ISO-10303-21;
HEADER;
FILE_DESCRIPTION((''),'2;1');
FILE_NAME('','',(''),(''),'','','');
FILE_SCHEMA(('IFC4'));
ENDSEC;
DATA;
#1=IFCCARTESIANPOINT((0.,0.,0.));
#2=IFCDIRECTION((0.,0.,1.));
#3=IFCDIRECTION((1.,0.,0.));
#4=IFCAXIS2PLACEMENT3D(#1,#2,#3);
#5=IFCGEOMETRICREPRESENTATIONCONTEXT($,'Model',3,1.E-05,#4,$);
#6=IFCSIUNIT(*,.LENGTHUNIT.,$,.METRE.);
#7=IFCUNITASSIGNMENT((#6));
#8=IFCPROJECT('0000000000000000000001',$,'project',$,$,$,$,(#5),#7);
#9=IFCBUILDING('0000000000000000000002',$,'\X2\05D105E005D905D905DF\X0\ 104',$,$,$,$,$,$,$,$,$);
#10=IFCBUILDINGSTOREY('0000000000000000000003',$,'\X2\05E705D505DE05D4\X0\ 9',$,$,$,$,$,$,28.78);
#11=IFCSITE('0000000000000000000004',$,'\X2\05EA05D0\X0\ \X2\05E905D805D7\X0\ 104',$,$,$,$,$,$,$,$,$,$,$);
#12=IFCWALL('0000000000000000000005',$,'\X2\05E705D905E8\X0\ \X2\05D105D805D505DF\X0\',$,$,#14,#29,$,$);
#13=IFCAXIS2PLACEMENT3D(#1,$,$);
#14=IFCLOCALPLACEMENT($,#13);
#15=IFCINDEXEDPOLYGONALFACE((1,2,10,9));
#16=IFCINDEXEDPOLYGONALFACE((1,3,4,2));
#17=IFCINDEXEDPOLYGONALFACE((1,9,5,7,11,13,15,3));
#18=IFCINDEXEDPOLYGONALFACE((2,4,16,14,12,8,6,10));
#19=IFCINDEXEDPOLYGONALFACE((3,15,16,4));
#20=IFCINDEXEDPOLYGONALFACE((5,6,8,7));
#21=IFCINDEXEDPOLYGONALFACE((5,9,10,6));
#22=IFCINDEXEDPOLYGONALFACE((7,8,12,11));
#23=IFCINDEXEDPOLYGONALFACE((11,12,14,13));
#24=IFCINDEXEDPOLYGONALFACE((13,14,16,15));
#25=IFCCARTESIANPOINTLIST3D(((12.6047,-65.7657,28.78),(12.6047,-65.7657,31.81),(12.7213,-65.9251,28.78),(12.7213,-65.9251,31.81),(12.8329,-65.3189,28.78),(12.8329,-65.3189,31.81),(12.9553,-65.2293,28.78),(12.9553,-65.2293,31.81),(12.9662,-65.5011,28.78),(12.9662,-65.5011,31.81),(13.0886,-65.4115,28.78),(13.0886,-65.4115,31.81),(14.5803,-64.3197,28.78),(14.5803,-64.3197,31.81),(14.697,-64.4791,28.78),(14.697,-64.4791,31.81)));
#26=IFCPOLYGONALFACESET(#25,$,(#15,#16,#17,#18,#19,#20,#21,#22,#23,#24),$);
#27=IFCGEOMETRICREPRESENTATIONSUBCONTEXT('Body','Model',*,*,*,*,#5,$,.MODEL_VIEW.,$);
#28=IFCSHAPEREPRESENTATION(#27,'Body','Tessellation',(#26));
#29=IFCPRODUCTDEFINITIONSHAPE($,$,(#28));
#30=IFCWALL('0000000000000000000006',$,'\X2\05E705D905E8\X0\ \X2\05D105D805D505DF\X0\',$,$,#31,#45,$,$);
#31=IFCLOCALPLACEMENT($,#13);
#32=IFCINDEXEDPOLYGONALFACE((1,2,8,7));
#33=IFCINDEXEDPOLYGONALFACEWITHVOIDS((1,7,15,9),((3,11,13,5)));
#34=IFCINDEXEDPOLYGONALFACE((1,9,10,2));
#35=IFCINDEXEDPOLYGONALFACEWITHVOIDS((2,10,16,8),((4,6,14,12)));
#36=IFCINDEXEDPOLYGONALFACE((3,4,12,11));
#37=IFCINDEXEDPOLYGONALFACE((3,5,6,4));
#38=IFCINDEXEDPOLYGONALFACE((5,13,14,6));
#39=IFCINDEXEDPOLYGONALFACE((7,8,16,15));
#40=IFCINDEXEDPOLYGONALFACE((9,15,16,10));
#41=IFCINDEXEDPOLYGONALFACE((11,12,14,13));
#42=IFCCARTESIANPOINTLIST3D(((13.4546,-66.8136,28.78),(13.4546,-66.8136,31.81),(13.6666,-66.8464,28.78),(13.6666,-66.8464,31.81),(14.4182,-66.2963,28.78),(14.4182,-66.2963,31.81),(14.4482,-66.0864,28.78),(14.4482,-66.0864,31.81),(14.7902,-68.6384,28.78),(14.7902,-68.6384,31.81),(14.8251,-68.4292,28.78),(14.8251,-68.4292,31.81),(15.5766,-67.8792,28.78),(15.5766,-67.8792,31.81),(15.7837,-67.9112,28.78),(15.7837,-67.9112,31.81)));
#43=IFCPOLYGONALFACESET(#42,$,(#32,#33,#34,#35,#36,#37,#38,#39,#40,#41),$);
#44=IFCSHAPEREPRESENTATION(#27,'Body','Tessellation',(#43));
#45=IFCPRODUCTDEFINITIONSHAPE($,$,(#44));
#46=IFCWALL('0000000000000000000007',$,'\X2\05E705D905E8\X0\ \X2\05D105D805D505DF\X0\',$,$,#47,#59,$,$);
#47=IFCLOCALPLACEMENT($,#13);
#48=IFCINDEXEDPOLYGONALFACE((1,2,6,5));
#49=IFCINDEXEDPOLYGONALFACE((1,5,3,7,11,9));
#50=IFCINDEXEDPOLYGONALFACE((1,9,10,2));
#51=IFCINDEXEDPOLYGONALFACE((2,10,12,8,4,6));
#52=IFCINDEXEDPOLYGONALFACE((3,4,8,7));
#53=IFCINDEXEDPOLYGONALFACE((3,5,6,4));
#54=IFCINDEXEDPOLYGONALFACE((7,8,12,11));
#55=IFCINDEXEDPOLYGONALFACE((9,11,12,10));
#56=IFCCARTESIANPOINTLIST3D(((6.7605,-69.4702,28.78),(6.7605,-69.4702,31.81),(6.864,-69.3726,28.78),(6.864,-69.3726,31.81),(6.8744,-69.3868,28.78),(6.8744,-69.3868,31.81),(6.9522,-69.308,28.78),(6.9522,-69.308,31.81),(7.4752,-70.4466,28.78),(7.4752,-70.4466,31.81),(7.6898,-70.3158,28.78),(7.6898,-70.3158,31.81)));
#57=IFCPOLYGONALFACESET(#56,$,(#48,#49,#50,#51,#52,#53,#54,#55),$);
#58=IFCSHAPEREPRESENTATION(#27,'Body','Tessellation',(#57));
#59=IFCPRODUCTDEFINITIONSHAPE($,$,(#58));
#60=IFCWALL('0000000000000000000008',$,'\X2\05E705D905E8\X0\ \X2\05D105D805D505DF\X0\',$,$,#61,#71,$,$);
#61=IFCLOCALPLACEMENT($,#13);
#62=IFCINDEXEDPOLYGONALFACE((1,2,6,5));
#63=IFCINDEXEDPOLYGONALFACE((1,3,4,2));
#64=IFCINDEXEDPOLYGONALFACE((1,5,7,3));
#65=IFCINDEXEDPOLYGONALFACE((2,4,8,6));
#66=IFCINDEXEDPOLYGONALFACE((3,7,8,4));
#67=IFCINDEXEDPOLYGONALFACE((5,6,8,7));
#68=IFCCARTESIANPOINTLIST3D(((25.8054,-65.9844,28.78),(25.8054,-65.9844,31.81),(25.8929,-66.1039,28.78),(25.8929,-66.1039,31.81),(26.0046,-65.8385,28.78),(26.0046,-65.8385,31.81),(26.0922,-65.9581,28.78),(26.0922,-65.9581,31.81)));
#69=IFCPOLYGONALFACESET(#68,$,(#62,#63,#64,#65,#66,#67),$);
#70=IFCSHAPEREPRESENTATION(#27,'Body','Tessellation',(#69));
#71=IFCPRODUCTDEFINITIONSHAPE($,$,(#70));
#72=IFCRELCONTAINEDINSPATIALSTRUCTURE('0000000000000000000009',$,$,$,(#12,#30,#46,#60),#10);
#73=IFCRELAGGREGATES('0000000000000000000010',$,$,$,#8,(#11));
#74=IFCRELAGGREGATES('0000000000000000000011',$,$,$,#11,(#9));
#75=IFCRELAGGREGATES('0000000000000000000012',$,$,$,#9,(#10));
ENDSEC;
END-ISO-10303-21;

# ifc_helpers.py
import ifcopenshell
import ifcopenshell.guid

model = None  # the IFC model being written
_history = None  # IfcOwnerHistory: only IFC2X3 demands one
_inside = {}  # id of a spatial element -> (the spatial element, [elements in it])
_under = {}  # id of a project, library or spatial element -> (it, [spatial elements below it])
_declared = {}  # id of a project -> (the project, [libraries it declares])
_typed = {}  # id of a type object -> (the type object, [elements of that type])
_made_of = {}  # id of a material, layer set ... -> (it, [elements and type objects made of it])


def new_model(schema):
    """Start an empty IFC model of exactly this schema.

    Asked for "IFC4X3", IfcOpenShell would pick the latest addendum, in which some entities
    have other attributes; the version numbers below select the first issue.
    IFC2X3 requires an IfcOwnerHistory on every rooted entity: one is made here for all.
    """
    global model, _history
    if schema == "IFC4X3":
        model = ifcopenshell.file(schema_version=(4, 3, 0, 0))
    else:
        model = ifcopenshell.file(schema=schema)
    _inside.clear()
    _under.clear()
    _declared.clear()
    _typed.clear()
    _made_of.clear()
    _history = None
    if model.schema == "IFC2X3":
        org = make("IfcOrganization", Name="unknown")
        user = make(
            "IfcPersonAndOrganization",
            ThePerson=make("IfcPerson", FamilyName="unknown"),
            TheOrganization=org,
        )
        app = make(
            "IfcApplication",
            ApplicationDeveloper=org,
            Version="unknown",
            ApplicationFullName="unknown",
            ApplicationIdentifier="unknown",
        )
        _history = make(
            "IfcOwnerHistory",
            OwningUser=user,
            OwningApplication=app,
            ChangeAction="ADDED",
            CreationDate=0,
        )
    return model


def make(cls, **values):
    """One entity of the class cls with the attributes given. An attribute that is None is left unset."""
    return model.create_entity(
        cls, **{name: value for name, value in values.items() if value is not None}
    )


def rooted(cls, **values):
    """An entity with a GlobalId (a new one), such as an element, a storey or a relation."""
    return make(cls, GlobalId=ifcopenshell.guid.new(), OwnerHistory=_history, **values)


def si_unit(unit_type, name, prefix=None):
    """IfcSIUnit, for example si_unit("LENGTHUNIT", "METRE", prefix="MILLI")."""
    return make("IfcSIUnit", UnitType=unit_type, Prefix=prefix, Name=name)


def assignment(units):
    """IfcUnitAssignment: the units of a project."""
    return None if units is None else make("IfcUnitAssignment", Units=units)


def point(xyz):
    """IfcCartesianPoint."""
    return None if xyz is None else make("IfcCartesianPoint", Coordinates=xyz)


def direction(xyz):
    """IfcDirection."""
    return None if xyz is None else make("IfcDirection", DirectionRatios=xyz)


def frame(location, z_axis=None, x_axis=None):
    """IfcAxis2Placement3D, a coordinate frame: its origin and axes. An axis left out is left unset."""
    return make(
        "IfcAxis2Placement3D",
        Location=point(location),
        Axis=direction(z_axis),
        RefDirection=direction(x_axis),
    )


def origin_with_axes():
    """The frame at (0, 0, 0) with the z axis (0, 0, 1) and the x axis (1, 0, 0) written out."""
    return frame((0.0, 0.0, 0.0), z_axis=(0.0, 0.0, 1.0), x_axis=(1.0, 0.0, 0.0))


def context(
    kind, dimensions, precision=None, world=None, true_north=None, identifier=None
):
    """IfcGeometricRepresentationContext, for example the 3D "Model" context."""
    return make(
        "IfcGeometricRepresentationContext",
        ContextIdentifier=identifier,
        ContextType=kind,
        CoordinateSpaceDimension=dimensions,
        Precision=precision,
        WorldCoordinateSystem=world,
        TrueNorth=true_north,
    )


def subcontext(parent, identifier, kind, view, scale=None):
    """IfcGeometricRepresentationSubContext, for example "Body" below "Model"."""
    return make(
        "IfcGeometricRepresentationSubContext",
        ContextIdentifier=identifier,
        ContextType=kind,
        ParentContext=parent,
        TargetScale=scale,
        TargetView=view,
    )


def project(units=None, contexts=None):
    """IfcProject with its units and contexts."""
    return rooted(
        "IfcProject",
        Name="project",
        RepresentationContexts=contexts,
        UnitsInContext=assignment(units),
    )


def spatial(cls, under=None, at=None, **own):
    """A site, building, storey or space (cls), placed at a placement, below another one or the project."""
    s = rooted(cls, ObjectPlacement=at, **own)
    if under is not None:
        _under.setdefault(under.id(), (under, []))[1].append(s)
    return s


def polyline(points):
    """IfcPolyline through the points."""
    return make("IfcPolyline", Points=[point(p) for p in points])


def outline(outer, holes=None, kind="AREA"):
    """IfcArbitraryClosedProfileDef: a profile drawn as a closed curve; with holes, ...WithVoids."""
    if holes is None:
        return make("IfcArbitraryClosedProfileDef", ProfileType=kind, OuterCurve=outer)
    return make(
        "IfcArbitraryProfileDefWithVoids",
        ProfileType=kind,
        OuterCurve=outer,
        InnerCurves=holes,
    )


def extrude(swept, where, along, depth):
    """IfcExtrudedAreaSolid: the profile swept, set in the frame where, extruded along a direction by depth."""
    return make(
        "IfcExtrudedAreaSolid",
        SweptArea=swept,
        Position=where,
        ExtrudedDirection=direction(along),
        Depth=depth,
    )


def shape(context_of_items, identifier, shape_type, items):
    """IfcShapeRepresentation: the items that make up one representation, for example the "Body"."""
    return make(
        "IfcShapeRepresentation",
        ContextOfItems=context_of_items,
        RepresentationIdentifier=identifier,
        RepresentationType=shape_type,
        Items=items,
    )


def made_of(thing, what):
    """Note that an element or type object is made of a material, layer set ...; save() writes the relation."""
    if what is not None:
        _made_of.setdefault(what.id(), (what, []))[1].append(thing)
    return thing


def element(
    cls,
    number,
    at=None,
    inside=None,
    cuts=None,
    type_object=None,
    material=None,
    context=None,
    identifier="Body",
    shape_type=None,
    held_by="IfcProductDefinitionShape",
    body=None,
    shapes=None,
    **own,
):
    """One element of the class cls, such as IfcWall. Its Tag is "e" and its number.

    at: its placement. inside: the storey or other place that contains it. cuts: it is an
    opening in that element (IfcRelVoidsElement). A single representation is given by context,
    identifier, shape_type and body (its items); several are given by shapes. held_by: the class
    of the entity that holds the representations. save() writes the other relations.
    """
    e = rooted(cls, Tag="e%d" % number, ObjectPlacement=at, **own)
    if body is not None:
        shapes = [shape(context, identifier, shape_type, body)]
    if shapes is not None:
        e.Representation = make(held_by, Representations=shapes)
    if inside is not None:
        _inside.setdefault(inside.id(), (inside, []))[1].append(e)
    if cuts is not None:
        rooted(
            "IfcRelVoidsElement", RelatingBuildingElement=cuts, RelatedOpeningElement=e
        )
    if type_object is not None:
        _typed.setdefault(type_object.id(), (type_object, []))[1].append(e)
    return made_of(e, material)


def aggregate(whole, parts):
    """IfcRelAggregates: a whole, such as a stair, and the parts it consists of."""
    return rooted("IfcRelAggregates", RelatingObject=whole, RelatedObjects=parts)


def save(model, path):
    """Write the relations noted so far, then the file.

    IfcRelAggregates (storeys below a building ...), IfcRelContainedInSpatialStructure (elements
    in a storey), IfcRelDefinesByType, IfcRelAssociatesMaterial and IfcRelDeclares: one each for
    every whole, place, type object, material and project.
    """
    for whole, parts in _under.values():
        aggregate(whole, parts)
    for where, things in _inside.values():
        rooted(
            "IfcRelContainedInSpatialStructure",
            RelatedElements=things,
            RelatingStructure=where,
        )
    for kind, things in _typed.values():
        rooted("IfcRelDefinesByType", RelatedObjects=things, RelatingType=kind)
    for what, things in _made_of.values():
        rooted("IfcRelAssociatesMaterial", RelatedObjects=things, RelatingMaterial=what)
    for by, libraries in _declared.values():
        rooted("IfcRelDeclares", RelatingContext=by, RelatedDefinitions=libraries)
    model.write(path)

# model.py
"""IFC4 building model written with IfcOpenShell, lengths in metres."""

from ifc_helpers import new_model, si_unit, frame, origin_with_axes, context, subcontext, project, spatial, polyline, outline, extrude, element, save


model = new_model("IFC4")

# Units and contexts
model_context = context("Model", 3, precision=1e-05, world=origin_with_axes())
body_context = subcontext(model_context, "Body", "Model", "MODEL_VIEW")
ifc_project = project(units=[si_unit("LENGTHUNIT", "METRE")], contexts=[model_context])

# Site, building, storey
site = spatial("IfcSite", under=ifc_project, Name="תא שטח 104")
building = spatial("IfcBuilding", under=site, Name="בניין 104")
storey = spatial("IfcBuildingStorey", under=building, Name="קומה 9", Elevation=28.78)

# Walls
element("IfcWall", 1, inside=storey, Name="קיר בטון", context=body_context, shape_type="SweptSolid", body=[
    extrude(outline(polyline([(12.6047, -65.7657), (12.7213, -65.9251), (14.697, -64.4791), (14.5803, -64.3197), (13.0886, -65.4115), (12.9553, -65.2293), (12.8329, -65.3189), (12.9662, -65.5011), (12.6047, -65.7657)])), frame((0.0, 0.0, 28.78)), (0.0, 0.0, 1.0), 3.03),
])
element("IfcWall", 2, inside=storey, Name="קיר בטון", context=body_context, shape_type="SweptSolid", body=[
    extrude(outline(polyline([(14.4482, -66.0864), (13.4546, -66.8136), (14.7902, -68.6384), (15.7837, -67.9112), (14.4482, -66.0864)]), holes=[polyline([(14.4182, -66.2963), (15.5766, -67.8792), (14.8251, -68.4292), (13.6666, -66.8464), (14.4182, -66.2963)])]), frame((0.0, 0.0, 28.78)), (0.0, 0.0, 1.0), 3.03),
])
element("IfcWall", 3, inside=storey, Name="קיר בטון", context=body_context, shape_type="SweptSolid", body=[
    extrude(outline(polyline([(6.864, -69.3726), (6.8744, -69.3868), (6.7605, -69.4702), (7.4752, -70.4466), (7.6898, -70.3158), (6.9522, -69.308), (6.864, -69.3726)])), frame((0.0, 0.0, 28.78)), (0.0, 0.0, 1.0), 3.03),
])
element("IfcWall", 4, inside=storey, Name="קיר בטון", context=body_context, shape_type="SweptSolid", body=[
    extrude(outline(polyline([(26.0922, -65.9581), (26.0046, -65.8385), (25.8054, -65.9844), (25.8929, -66.1039), (26.0922, -65.9581)])), frame((0.0, 0.0, 28.78)), (0.0, 0.0, 1.0), 3.03),
])

save(model, "model.ifc")
